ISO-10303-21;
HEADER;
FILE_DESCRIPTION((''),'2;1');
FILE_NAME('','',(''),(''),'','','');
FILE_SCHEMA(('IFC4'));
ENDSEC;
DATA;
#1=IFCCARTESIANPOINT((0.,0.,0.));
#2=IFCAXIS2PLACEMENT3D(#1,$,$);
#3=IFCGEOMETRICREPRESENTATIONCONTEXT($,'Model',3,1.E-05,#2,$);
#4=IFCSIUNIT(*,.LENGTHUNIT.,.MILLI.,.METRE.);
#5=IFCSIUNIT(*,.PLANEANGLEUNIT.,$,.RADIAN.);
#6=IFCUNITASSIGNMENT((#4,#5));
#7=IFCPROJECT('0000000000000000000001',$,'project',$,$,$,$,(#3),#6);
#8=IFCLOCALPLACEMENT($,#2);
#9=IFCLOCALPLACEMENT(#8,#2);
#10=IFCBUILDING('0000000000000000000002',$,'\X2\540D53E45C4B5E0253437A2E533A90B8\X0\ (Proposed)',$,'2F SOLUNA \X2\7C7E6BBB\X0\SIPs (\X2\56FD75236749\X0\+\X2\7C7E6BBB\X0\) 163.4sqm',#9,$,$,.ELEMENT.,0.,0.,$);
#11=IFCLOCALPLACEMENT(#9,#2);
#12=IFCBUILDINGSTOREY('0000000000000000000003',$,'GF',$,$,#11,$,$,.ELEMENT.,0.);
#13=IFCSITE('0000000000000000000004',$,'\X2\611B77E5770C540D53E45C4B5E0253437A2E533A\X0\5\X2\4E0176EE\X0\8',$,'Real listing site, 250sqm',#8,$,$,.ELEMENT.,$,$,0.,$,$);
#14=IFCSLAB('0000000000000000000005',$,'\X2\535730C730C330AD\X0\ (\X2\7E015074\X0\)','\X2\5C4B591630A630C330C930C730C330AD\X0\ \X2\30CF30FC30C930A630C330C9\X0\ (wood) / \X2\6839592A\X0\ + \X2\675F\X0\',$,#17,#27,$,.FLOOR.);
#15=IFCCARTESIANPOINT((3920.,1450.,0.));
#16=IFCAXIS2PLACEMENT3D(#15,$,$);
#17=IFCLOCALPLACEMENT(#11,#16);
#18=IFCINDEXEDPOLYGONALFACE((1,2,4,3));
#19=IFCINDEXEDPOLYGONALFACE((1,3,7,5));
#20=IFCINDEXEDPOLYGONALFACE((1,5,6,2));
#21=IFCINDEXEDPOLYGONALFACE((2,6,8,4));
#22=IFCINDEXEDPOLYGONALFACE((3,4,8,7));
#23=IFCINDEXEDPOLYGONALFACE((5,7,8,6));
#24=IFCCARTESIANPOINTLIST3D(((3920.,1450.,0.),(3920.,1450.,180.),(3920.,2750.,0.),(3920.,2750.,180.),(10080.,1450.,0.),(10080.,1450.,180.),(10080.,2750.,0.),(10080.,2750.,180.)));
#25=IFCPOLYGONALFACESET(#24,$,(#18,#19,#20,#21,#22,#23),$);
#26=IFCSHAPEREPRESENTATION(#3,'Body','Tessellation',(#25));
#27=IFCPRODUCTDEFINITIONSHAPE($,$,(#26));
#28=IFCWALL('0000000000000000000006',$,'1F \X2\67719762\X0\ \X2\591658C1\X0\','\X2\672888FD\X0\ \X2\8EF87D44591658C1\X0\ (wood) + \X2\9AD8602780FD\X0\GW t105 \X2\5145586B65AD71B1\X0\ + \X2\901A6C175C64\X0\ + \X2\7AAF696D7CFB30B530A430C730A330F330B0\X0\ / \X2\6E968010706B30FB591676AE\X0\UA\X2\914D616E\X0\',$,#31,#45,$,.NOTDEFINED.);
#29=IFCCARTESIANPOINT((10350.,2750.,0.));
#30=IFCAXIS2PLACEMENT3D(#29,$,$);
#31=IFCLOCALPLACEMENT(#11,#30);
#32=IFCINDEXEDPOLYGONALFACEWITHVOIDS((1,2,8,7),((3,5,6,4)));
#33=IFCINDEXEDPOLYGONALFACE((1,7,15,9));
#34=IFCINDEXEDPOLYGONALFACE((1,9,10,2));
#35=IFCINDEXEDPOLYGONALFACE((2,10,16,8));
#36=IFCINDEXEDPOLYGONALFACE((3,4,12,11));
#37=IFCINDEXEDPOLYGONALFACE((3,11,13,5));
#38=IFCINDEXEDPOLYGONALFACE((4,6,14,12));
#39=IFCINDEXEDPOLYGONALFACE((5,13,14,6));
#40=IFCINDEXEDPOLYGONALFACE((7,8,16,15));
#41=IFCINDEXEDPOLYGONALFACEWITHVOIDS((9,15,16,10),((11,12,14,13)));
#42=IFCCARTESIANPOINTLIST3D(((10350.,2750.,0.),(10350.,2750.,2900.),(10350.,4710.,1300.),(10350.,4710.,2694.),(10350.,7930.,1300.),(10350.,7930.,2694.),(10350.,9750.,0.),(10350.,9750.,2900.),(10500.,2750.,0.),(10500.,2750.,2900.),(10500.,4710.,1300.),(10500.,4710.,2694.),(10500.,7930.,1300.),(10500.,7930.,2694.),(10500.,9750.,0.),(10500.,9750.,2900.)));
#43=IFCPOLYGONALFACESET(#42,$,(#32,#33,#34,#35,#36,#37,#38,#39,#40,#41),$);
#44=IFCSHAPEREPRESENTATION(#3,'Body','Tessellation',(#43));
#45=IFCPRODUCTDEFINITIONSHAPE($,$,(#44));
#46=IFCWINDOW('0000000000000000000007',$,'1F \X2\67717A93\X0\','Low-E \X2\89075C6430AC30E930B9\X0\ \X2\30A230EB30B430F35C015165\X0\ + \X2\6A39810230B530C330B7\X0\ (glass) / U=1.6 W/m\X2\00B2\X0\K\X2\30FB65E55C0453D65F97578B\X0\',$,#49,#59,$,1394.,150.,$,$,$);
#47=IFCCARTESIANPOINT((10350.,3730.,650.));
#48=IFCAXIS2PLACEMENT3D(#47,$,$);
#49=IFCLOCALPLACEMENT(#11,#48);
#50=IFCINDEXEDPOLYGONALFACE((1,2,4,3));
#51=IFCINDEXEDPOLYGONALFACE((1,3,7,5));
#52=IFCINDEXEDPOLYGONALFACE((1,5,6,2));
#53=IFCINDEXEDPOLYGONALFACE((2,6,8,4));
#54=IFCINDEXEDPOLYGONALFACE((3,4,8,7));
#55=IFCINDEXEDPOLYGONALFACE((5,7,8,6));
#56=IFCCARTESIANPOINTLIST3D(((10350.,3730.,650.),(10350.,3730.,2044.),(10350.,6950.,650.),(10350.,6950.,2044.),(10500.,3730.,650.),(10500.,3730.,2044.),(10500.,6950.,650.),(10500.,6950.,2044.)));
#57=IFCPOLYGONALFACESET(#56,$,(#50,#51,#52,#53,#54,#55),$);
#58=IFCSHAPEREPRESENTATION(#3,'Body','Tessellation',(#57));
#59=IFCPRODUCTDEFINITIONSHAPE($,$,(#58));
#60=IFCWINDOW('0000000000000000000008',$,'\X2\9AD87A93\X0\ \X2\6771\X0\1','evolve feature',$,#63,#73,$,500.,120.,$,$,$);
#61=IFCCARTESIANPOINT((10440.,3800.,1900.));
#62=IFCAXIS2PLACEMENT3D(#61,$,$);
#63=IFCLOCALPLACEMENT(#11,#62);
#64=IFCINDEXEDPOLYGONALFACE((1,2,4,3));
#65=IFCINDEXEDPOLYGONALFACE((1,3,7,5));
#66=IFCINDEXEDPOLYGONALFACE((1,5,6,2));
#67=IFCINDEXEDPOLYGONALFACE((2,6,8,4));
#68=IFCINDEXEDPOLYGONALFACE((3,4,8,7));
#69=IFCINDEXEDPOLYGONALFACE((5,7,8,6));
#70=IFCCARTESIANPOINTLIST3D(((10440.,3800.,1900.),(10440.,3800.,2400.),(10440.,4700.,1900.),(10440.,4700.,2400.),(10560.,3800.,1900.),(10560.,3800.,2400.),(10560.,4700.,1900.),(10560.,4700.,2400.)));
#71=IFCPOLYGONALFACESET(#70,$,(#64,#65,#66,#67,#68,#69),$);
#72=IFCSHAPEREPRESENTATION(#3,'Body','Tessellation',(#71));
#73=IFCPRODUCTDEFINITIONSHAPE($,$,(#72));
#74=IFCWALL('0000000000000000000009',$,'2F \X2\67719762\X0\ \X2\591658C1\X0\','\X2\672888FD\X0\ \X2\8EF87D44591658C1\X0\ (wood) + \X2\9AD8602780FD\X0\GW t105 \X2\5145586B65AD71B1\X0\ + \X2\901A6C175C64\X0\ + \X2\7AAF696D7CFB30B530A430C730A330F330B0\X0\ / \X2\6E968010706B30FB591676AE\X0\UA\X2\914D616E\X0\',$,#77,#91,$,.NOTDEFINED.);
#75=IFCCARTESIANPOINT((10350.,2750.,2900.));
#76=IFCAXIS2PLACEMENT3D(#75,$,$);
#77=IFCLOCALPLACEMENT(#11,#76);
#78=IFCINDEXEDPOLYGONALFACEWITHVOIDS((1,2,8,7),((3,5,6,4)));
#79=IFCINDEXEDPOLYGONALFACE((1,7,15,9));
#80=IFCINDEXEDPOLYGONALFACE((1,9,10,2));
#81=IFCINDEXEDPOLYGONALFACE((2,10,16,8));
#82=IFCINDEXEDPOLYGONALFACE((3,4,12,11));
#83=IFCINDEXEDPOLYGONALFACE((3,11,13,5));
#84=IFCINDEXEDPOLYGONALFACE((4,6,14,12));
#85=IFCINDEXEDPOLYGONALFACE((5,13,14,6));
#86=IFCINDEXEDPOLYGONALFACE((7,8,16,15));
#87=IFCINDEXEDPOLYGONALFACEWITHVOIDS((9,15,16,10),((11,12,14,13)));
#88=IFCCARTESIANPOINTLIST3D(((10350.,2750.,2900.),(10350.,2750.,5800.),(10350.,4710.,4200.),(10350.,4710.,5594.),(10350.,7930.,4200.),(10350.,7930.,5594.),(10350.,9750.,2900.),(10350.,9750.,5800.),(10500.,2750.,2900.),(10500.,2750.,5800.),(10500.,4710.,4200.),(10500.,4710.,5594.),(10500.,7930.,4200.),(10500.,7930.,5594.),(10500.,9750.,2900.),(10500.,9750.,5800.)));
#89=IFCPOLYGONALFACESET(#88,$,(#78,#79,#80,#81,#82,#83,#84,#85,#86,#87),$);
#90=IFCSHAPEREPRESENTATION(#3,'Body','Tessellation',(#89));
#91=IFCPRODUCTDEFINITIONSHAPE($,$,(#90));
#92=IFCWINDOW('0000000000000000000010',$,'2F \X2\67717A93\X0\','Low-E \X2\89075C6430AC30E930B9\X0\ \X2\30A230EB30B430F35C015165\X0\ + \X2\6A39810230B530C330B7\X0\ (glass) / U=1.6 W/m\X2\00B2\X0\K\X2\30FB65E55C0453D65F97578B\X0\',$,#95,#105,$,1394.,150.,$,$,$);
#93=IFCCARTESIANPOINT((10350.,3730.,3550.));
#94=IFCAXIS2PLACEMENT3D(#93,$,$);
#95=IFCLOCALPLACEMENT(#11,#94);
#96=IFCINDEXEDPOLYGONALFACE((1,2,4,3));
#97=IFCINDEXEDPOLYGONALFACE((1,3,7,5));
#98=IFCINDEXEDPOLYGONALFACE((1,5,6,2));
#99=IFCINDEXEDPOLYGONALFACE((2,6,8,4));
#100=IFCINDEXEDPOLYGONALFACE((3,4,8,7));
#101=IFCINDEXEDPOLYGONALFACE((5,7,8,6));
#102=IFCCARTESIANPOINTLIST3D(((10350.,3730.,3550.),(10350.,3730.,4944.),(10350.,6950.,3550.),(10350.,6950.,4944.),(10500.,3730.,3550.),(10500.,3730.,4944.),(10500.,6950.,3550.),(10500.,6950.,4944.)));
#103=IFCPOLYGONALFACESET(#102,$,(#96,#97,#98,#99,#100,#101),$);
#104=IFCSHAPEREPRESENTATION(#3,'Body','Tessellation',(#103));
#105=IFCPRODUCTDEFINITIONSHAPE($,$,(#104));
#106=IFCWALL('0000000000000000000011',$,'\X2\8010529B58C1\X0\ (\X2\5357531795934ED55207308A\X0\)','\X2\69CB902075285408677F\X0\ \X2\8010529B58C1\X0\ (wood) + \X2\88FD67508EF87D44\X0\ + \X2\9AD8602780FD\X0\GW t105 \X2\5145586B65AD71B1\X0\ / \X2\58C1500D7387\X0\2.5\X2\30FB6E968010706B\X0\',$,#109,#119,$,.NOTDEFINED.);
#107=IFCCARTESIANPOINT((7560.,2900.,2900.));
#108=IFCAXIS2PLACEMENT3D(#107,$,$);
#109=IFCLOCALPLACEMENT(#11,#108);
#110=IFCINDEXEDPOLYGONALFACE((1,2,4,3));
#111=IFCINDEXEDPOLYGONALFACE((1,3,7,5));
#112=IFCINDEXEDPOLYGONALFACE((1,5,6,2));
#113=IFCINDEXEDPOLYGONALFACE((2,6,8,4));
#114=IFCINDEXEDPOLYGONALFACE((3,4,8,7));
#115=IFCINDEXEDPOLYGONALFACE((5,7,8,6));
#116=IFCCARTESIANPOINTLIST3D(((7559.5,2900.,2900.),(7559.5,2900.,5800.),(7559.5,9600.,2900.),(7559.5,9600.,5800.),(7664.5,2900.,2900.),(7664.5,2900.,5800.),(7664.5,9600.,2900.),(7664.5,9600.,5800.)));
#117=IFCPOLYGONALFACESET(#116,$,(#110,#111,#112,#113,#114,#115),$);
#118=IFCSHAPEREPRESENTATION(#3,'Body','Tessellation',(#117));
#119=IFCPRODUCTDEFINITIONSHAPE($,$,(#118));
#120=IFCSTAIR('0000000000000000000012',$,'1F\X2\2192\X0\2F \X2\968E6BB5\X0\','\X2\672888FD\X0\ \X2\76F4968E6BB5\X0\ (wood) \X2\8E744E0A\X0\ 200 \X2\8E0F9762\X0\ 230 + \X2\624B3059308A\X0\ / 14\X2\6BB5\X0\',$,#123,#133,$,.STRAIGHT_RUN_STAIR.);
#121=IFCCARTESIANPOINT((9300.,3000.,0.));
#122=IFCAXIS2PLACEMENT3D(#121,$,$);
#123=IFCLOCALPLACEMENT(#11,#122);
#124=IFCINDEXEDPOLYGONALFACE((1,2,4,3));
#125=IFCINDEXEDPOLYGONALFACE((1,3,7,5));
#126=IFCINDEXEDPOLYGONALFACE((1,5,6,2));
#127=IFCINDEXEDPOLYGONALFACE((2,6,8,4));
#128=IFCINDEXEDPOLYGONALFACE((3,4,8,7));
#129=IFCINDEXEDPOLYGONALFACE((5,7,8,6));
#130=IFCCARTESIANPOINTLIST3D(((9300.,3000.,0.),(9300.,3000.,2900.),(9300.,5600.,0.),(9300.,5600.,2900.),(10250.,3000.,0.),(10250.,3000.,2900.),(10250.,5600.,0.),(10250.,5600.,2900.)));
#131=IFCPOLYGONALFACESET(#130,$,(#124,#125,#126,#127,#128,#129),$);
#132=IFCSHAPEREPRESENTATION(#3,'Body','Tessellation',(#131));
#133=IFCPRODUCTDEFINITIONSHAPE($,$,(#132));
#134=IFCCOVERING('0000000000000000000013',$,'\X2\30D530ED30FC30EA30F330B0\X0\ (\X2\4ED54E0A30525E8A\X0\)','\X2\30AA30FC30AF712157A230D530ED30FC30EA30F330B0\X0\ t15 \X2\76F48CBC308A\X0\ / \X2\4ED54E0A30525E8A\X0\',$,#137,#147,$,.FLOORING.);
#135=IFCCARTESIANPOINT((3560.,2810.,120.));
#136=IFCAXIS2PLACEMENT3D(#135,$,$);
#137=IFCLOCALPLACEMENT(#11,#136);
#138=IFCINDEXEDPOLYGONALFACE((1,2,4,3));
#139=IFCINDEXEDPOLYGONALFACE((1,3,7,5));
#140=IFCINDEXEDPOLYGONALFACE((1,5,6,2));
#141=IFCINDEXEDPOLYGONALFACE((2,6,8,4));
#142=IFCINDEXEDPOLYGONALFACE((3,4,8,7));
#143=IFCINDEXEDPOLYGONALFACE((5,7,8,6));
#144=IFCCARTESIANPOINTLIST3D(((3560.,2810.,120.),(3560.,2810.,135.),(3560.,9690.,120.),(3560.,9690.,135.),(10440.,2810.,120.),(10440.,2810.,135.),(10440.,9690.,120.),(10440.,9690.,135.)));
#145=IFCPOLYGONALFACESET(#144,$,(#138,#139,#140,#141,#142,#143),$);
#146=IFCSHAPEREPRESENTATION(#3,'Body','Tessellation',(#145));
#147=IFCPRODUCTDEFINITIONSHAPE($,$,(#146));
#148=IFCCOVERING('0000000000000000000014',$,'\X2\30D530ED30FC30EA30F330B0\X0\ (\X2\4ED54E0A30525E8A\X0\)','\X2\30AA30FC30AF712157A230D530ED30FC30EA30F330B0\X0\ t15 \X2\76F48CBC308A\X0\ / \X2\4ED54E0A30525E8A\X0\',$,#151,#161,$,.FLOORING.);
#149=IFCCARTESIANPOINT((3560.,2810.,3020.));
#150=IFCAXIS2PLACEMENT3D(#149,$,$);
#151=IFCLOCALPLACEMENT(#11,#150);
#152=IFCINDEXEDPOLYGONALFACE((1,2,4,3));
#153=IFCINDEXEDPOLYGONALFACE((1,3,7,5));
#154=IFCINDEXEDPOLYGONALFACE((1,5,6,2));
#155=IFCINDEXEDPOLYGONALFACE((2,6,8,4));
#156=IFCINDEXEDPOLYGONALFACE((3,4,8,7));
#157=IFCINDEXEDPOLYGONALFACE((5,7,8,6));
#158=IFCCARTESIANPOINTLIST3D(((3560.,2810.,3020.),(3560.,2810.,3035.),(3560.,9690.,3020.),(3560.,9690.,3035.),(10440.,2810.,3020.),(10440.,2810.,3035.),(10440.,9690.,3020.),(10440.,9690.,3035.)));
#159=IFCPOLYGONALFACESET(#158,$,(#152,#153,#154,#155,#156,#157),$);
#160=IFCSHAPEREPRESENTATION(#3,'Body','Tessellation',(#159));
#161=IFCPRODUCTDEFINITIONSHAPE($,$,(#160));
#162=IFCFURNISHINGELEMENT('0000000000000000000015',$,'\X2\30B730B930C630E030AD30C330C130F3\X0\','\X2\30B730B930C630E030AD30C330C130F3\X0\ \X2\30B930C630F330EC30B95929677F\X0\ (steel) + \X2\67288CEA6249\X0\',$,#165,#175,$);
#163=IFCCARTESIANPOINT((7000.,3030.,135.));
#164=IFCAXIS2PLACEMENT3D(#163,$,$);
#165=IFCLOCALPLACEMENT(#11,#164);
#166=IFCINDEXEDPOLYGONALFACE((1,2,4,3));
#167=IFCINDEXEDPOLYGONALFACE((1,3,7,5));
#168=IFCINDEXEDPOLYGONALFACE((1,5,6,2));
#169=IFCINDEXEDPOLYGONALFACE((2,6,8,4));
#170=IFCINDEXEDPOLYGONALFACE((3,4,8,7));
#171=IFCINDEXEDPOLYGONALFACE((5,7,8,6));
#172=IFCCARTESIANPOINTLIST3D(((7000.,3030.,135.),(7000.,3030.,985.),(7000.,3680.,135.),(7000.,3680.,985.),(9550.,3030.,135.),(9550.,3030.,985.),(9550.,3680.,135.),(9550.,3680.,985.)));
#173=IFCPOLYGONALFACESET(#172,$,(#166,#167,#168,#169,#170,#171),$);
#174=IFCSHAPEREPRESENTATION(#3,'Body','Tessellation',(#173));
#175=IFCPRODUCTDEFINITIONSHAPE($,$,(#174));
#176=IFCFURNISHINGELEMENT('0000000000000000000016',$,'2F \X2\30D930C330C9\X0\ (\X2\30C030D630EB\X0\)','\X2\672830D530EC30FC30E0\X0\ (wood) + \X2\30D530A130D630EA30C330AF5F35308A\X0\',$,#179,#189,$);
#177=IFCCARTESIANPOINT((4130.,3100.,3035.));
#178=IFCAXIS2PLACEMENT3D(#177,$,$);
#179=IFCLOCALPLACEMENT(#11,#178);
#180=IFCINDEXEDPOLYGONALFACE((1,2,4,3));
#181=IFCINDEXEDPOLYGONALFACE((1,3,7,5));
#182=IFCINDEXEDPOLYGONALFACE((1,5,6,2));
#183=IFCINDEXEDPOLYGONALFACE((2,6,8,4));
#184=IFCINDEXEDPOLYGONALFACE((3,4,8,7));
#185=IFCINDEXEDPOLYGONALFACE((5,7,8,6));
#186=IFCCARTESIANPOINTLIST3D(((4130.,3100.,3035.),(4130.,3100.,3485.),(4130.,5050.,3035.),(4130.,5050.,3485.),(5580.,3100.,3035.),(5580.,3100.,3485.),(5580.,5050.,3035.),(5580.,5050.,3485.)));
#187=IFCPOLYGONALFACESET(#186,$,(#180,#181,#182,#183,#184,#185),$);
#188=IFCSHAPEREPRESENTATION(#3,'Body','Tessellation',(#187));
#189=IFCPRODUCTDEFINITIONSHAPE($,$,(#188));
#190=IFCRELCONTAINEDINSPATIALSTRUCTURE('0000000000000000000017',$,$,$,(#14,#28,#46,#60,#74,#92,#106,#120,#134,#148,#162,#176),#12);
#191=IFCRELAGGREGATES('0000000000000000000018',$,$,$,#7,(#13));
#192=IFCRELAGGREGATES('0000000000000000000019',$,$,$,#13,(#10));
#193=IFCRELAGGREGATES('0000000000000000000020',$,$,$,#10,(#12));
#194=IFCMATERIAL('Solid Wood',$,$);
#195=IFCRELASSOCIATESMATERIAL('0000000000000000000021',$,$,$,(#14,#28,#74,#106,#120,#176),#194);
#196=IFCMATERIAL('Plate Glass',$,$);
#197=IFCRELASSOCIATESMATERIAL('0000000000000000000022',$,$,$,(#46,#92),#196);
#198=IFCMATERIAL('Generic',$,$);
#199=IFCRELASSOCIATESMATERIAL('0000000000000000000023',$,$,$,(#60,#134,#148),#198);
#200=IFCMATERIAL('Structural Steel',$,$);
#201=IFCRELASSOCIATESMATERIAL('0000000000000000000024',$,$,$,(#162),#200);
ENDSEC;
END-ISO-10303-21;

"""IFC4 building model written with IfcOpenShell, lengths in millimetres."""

from ifc_helpers import new_model, si_unit, frame, frame_2d, origin, place, context, project, spatial, rectangle, extrude, material, element, fill, save


model = new_model("IFC4")

# Units and contexts
model_context = context("Model", 3, precision=1e-05, world=origin())
ifc_project = project(units=[si_unit("LENGTHUNIT", "METRE", prefix="MILLI"), si_unit("PLANEANGLEUNIT", "RADIAN")], contexts=[model_context])

# Site, building, storey
site_placement = place(None, origin())
site = spatial("IfcSite", under=ifc_project, at=site_placement, Name="愛知県名古屋市千種区5丁目8", ObjectType="Real listing site, 250sqm", CompositionType="ELEMENT", RefElevation=0.0)
building_placement = place(site_placement, origin())
building = spatial("IfcBuilding", under=site, at=building_placement, Name="名古屋市千種区邸 (Proposed)", ObjectType="2F SOLUNA 籾殻SIPs (国産杉+籾殻) 163.4sqm", CompositionType="ELEMENT", ElevationOfRefHeight=0.0, ElevationOfTerrain=0.0)
storey_placement = place(building_placement, origin())
storey = spatial("IfcBuildingStorey", under=building, at=storey_placement, Name="GF", CompositionType="ELEMENT", Elevation=0.0)

# Slab
ifc_material_1 = material(Name="Solid Wood")
slab_placement = place(storey_placement, frame((3920.0, 1450.0, 0.0)))
element("IfcSlab", 1, at=slab_placement, inside=storey, material=ifc_material_1, Name="南デッキ (縁側)", Description="屋外ウッドデッキ ハードウッド (wood) / 根太 + 束", PredefinedType="FLOOR", context=model_context, shape_type="SweptSolid", body=[
    extrude(rectangle(XDim=6160.0, YDim=1300.0, at=frame_2d((3080.0, 650.0))), frame((3920.0, 1450.0, 0.0)), (0.0, 0.0, 1.0), 180.0),
])

# Wall, openings, windows
wall_1_placement = place(storey_placement, frame((10350.0, 2750.0, 0.0)))
wall_1 = element("IfcWall", 2, at=wall_1_placement, inside=storey, material=ifc_material_1, Name="1F 東面 外壁", Description="木製 軸組外壁 (wood) + 高性能GW t105 充填断熱 + 通気層 + 窯業系サイディング / 準耐火・外皮UA配慮", PredefinedType="NOTDEFINED", context=model_context, shape_type="SweptSolid", body=[
    extrude(rectangle(XDim=150.0, YDim=7000.0, at=frame_2d((75.0, 3500.0))), frame((10350.0, 2750.0, 0.0)), (0.0, 0.0, 1.0), 2900.0),
])
opening_1_placement = place(storey_placement, frame((10350.0, 3730.0, 650.0)))
opening_1 = element("IfcOpeningElement", 3, at=opening_1_placement, cuts=wall_1, PredefinedType="NOTDEFINED", context=model_context, shape_type="SweptSolid", body=[
    extrude(rectangle(XDim=150.0, YDim=3220.0, at=frame_2d((75.0, 1610.0))), frame((10350.0, 3730.0, 650.0)), (0.0, 0.0, 1.0), 1394.0),
])
opening_2_placement = place(storey_placement, frame((10440.0, 3800.0, 1900.0)))
opening_2 = element("IfcOpeningElement", 4, at=opening_2_placement, cuts=wall_1, PredefinedType="NOTDEFINED", context=model_context, shape_type="SweptSolid", body=[
    extrude(rectangle(XDim=120.0, YDim=900.0, at=frame_2d((60.0, 450.0))), frame((10440.0, 3800.0, 1900.0)), (0.0, 0.0, 1.0), 500.0),
])
ifc_material_2 = material(Name="Plate Glass")
window_1_placement = place(storey_placement, frame((10350.0, 3730.0, 650.0)))
window_1 = element("IfcWindow", 5, at=window_1_placement, inside=storey, material=ifc_material_2, Name="1F 東窓", Description="Low-E 複層ガラス アルゴン封入 + 樹脂サッシ (glass) / U=1.6 W/m²K・日射取得型", OverallHeight=1394.0, OverallWidth=150.0, context=model_context, shape_type="SweptSolid", body=[
    extrude(rectangle(XDim=150.0, YDim=3220.0, at=frame_2d((75.0, 1610.0))), frame((10350.0, 3730.0, 650.0)), (0.0, 0.0, 1.0), 1394.0),
])
fill(opening_1, window_1)
ifc_material_3 = material(Name="Generic")
window_2_placement = place(storey_placement, frame((10440.0, 3800.0, 1900.0)))
window_2 = element("IfcWindow", 6, at=window_2_placement, inside=storey, material=ifc_material_3, Name="高窓 東1", Description="evolve feature", OverallHeight=500.0, OverallWidth=120.0, context=model_context, shape_type="SweptSolid", body=[
    extrude(rectangle(XDim=120.0, YDim=900.0, at=frame_2d((60.0, 450.0))), frame((10440.0, 3800.0, 1900.0)), (0.0, 0.0, 1.0), 500.0),
])
fill(opening_2, window_2)

# Wall, opening, window
wall_2_placement = place(storey_placement, frame((10350.0, 2750.0, 2900.0)))
wall_2 = element("IfcWall", 7, at=wall_2_placement, inside=storey, material=ifc_material_1, Name="2F 東面 外壁", Description="木製 軸組外壁 (wood) + 高性能GW t105 充填断熱 + 通気層 + 窯業系サイディング / 準耐火・外皮UA配慮", PredefinedType="NOTDEFINED", context=model_context, shape_type="SweptSolid", body=[
    extrude(rectangle(XDim=150.0, YDim=7000.0, at=frame_2d((75.0, 3500.0))), frame((10350.0, 2750.0, 2900.0)), (0.0, 0.0, 1.0), 2900.0),
])
opening_3_placement = place(storey_placement, frame((10350.0, 3730.0, 3550.0)))
opening_3 = element("IfcOpeningElement", 8, at=opening_3_placement, cuts=wall_2, PredefinedType="NOTDEFINED", context=model_context, shape_type="SweptSolid", body=[
    extrude(rectangle(XDim=150.0, YDim=3220.0, at=frame_2d((75.0, 1610.0))), frame((10350.0, 3730.0, 3550.0)), (0.0, 0.0, 1.0), 1394.0),
])
window_3_placement = place(storey_placement, frame((10350.0, 3730.0, 3550.0)))
window_3 = element("IfcWindow", 9, at=window_3_placement, inside=storey, material=ifc_material_2, Name="2F 東窓", Description="Low-E 複層ガラス アルゴン封入 + 樹脂サッシ (glass) / U=1.6 W/m²K・日射取得型", OverallHeight=1394.0, OverallWidth=150.0, context=model_context, shape_type="SweptSolid", body=[
    extrude(rectangle(XDim=150.0, YDim=3220.0, at=frame_2d((75.0, 1610.0))), frame((10350.0, 3730.0, 3550.0)), (0.0, 0.0, 1.0), 1394.0),
])
fill(opening_3, window_3)

# Wall
wall_3_placement = place(storey_placement, frame((7560.0, 2900.0, 2900.0)))
element("IfcWall", 10, at=wall_3_placement, inside=storey, material=ifc_material_1, Name="耐力壁 (南北間仕切り)", Description="構造用合板 耐力壁 (wood) + 製材軸組 + 高性能GW t105 充填断熱 / 壁倍率2.5・準耐火", PredefinedType="NOTDEFINED", context=model_context, shape_type="SweptSolid", body=[
    extrude(rectangle(XDim=105.0, YDim=6700.0, at=frame_2d((52.0, 3350.0))), frame((7560.0, 2900.0, 2900.0)), (0.0, 0.0, 1.0), 2900.0),
])

# Stair
stair_placement = place(storey_placement, frame((9300.0, 3000.0, 0.0)))
element("IfcStair", 11, at=stair_placement, inside=storey, material=ifc_material_1, Name="1F→2F 階段", Description="木製 直階段 (wood) 蹴上 200 踏面 230 + 手すり / 14段", PredefinedType="STRAIGHT_RUN_STAIR", context=model_context, shape_type="SweptSolid", body=[
    extrude(rectangle(XDim=950.0, YDim=2600.0, at=frame_2d((475.0, 1300.0))), frame((9300.0, 3000.0, 0.0)), (0.0, 0.0, 1.0), 2900.0),
])

# Coverings
covering_1_placement = place(storey_placement, frame((3560.0, 2810.0, 120.0)))
element("IfcCovering", 12, at=covering_1_placement, inside=storey, material=ifc_material_3, Name="フローリング (仕上げ床)", Description="オーク無垢フローリング t15 直貼り / 仕上げ床", PredefinedType="FLOORING", context=model_context, shape_type="SweptSolid", body=[
    extrude(rectangle(XDim=6880.0, YDim=6880.0, at=frame_2d((3440.0, 3440.0))), frame((3560.0, 2810.0, 120.0)), (0.0, 0.0, 1.0), 15.0),
])
covering_2_placement = place(storey_placement, frame((3560.0, 2810.0, 3020.0)))
element("IfcCovering", 13, at=covering_2_placement, inside=storey, material=ifc_material_3, Name="フローリング (仕上げ床)", Description="オーク無垢フローリング t15 直貼り / 仕上げ床", PredefinedType="FLOORING", context=model_context, shape_type="SweptSolid", body=[
    extrude(rectangle(XDim=6880.0, YDim=6880.0, at=frame_2d((3440.0, 3440.0))), frame((3560.0, 2810.0, 3020.0)), (0.0, 0.0, 1.0), 15.0),
])

# Furnishing elements
ifc_material_4 = material(Name="Structural Steel")
furnishing_1_placement = place(storey_placement, frame((7000.0, 3030.0, 135.0)))
element("IfcFurnishingElement", 14, at=furnishing_1_placement, inside=storey, material=ifc_material_4, Name="システムキッチン", Description="システムキッチン ステンレス天板 (steel) + 木質扉", context=model_context, shape_type="SweptSolid", body=[
    extrude(rectangle(XDim=2550.0, YDim=650.0, at=frame_2d((1275.0, 325.0))), frame((7000.0, 3030.0, 135.0)), (0.0, 0.0, 1.0), 850.0),
])
furnishing_2_placement = place(storey_placement, frame((4130.0, 3100.0, 3035.0)))
element("IfcFurnishingElement", 15, at=furnishing_2_placement, inside=storey, material=ifc_material_1, Name="2F ベッド (ダブル)", Description="木フレーム (wood) + ファブリック張り", context=model_context, shape_type="SweptSolid", body=[
    extrude(rectangle(XDim=1450.0, YDim=1950.0, at=frame_2d((725.0, 975.0))), frame((4130.0, 3100.0, 3035.0)), (0.0, 0.0, 1.0), 450.0),
])

save(model, "model.ifc")
